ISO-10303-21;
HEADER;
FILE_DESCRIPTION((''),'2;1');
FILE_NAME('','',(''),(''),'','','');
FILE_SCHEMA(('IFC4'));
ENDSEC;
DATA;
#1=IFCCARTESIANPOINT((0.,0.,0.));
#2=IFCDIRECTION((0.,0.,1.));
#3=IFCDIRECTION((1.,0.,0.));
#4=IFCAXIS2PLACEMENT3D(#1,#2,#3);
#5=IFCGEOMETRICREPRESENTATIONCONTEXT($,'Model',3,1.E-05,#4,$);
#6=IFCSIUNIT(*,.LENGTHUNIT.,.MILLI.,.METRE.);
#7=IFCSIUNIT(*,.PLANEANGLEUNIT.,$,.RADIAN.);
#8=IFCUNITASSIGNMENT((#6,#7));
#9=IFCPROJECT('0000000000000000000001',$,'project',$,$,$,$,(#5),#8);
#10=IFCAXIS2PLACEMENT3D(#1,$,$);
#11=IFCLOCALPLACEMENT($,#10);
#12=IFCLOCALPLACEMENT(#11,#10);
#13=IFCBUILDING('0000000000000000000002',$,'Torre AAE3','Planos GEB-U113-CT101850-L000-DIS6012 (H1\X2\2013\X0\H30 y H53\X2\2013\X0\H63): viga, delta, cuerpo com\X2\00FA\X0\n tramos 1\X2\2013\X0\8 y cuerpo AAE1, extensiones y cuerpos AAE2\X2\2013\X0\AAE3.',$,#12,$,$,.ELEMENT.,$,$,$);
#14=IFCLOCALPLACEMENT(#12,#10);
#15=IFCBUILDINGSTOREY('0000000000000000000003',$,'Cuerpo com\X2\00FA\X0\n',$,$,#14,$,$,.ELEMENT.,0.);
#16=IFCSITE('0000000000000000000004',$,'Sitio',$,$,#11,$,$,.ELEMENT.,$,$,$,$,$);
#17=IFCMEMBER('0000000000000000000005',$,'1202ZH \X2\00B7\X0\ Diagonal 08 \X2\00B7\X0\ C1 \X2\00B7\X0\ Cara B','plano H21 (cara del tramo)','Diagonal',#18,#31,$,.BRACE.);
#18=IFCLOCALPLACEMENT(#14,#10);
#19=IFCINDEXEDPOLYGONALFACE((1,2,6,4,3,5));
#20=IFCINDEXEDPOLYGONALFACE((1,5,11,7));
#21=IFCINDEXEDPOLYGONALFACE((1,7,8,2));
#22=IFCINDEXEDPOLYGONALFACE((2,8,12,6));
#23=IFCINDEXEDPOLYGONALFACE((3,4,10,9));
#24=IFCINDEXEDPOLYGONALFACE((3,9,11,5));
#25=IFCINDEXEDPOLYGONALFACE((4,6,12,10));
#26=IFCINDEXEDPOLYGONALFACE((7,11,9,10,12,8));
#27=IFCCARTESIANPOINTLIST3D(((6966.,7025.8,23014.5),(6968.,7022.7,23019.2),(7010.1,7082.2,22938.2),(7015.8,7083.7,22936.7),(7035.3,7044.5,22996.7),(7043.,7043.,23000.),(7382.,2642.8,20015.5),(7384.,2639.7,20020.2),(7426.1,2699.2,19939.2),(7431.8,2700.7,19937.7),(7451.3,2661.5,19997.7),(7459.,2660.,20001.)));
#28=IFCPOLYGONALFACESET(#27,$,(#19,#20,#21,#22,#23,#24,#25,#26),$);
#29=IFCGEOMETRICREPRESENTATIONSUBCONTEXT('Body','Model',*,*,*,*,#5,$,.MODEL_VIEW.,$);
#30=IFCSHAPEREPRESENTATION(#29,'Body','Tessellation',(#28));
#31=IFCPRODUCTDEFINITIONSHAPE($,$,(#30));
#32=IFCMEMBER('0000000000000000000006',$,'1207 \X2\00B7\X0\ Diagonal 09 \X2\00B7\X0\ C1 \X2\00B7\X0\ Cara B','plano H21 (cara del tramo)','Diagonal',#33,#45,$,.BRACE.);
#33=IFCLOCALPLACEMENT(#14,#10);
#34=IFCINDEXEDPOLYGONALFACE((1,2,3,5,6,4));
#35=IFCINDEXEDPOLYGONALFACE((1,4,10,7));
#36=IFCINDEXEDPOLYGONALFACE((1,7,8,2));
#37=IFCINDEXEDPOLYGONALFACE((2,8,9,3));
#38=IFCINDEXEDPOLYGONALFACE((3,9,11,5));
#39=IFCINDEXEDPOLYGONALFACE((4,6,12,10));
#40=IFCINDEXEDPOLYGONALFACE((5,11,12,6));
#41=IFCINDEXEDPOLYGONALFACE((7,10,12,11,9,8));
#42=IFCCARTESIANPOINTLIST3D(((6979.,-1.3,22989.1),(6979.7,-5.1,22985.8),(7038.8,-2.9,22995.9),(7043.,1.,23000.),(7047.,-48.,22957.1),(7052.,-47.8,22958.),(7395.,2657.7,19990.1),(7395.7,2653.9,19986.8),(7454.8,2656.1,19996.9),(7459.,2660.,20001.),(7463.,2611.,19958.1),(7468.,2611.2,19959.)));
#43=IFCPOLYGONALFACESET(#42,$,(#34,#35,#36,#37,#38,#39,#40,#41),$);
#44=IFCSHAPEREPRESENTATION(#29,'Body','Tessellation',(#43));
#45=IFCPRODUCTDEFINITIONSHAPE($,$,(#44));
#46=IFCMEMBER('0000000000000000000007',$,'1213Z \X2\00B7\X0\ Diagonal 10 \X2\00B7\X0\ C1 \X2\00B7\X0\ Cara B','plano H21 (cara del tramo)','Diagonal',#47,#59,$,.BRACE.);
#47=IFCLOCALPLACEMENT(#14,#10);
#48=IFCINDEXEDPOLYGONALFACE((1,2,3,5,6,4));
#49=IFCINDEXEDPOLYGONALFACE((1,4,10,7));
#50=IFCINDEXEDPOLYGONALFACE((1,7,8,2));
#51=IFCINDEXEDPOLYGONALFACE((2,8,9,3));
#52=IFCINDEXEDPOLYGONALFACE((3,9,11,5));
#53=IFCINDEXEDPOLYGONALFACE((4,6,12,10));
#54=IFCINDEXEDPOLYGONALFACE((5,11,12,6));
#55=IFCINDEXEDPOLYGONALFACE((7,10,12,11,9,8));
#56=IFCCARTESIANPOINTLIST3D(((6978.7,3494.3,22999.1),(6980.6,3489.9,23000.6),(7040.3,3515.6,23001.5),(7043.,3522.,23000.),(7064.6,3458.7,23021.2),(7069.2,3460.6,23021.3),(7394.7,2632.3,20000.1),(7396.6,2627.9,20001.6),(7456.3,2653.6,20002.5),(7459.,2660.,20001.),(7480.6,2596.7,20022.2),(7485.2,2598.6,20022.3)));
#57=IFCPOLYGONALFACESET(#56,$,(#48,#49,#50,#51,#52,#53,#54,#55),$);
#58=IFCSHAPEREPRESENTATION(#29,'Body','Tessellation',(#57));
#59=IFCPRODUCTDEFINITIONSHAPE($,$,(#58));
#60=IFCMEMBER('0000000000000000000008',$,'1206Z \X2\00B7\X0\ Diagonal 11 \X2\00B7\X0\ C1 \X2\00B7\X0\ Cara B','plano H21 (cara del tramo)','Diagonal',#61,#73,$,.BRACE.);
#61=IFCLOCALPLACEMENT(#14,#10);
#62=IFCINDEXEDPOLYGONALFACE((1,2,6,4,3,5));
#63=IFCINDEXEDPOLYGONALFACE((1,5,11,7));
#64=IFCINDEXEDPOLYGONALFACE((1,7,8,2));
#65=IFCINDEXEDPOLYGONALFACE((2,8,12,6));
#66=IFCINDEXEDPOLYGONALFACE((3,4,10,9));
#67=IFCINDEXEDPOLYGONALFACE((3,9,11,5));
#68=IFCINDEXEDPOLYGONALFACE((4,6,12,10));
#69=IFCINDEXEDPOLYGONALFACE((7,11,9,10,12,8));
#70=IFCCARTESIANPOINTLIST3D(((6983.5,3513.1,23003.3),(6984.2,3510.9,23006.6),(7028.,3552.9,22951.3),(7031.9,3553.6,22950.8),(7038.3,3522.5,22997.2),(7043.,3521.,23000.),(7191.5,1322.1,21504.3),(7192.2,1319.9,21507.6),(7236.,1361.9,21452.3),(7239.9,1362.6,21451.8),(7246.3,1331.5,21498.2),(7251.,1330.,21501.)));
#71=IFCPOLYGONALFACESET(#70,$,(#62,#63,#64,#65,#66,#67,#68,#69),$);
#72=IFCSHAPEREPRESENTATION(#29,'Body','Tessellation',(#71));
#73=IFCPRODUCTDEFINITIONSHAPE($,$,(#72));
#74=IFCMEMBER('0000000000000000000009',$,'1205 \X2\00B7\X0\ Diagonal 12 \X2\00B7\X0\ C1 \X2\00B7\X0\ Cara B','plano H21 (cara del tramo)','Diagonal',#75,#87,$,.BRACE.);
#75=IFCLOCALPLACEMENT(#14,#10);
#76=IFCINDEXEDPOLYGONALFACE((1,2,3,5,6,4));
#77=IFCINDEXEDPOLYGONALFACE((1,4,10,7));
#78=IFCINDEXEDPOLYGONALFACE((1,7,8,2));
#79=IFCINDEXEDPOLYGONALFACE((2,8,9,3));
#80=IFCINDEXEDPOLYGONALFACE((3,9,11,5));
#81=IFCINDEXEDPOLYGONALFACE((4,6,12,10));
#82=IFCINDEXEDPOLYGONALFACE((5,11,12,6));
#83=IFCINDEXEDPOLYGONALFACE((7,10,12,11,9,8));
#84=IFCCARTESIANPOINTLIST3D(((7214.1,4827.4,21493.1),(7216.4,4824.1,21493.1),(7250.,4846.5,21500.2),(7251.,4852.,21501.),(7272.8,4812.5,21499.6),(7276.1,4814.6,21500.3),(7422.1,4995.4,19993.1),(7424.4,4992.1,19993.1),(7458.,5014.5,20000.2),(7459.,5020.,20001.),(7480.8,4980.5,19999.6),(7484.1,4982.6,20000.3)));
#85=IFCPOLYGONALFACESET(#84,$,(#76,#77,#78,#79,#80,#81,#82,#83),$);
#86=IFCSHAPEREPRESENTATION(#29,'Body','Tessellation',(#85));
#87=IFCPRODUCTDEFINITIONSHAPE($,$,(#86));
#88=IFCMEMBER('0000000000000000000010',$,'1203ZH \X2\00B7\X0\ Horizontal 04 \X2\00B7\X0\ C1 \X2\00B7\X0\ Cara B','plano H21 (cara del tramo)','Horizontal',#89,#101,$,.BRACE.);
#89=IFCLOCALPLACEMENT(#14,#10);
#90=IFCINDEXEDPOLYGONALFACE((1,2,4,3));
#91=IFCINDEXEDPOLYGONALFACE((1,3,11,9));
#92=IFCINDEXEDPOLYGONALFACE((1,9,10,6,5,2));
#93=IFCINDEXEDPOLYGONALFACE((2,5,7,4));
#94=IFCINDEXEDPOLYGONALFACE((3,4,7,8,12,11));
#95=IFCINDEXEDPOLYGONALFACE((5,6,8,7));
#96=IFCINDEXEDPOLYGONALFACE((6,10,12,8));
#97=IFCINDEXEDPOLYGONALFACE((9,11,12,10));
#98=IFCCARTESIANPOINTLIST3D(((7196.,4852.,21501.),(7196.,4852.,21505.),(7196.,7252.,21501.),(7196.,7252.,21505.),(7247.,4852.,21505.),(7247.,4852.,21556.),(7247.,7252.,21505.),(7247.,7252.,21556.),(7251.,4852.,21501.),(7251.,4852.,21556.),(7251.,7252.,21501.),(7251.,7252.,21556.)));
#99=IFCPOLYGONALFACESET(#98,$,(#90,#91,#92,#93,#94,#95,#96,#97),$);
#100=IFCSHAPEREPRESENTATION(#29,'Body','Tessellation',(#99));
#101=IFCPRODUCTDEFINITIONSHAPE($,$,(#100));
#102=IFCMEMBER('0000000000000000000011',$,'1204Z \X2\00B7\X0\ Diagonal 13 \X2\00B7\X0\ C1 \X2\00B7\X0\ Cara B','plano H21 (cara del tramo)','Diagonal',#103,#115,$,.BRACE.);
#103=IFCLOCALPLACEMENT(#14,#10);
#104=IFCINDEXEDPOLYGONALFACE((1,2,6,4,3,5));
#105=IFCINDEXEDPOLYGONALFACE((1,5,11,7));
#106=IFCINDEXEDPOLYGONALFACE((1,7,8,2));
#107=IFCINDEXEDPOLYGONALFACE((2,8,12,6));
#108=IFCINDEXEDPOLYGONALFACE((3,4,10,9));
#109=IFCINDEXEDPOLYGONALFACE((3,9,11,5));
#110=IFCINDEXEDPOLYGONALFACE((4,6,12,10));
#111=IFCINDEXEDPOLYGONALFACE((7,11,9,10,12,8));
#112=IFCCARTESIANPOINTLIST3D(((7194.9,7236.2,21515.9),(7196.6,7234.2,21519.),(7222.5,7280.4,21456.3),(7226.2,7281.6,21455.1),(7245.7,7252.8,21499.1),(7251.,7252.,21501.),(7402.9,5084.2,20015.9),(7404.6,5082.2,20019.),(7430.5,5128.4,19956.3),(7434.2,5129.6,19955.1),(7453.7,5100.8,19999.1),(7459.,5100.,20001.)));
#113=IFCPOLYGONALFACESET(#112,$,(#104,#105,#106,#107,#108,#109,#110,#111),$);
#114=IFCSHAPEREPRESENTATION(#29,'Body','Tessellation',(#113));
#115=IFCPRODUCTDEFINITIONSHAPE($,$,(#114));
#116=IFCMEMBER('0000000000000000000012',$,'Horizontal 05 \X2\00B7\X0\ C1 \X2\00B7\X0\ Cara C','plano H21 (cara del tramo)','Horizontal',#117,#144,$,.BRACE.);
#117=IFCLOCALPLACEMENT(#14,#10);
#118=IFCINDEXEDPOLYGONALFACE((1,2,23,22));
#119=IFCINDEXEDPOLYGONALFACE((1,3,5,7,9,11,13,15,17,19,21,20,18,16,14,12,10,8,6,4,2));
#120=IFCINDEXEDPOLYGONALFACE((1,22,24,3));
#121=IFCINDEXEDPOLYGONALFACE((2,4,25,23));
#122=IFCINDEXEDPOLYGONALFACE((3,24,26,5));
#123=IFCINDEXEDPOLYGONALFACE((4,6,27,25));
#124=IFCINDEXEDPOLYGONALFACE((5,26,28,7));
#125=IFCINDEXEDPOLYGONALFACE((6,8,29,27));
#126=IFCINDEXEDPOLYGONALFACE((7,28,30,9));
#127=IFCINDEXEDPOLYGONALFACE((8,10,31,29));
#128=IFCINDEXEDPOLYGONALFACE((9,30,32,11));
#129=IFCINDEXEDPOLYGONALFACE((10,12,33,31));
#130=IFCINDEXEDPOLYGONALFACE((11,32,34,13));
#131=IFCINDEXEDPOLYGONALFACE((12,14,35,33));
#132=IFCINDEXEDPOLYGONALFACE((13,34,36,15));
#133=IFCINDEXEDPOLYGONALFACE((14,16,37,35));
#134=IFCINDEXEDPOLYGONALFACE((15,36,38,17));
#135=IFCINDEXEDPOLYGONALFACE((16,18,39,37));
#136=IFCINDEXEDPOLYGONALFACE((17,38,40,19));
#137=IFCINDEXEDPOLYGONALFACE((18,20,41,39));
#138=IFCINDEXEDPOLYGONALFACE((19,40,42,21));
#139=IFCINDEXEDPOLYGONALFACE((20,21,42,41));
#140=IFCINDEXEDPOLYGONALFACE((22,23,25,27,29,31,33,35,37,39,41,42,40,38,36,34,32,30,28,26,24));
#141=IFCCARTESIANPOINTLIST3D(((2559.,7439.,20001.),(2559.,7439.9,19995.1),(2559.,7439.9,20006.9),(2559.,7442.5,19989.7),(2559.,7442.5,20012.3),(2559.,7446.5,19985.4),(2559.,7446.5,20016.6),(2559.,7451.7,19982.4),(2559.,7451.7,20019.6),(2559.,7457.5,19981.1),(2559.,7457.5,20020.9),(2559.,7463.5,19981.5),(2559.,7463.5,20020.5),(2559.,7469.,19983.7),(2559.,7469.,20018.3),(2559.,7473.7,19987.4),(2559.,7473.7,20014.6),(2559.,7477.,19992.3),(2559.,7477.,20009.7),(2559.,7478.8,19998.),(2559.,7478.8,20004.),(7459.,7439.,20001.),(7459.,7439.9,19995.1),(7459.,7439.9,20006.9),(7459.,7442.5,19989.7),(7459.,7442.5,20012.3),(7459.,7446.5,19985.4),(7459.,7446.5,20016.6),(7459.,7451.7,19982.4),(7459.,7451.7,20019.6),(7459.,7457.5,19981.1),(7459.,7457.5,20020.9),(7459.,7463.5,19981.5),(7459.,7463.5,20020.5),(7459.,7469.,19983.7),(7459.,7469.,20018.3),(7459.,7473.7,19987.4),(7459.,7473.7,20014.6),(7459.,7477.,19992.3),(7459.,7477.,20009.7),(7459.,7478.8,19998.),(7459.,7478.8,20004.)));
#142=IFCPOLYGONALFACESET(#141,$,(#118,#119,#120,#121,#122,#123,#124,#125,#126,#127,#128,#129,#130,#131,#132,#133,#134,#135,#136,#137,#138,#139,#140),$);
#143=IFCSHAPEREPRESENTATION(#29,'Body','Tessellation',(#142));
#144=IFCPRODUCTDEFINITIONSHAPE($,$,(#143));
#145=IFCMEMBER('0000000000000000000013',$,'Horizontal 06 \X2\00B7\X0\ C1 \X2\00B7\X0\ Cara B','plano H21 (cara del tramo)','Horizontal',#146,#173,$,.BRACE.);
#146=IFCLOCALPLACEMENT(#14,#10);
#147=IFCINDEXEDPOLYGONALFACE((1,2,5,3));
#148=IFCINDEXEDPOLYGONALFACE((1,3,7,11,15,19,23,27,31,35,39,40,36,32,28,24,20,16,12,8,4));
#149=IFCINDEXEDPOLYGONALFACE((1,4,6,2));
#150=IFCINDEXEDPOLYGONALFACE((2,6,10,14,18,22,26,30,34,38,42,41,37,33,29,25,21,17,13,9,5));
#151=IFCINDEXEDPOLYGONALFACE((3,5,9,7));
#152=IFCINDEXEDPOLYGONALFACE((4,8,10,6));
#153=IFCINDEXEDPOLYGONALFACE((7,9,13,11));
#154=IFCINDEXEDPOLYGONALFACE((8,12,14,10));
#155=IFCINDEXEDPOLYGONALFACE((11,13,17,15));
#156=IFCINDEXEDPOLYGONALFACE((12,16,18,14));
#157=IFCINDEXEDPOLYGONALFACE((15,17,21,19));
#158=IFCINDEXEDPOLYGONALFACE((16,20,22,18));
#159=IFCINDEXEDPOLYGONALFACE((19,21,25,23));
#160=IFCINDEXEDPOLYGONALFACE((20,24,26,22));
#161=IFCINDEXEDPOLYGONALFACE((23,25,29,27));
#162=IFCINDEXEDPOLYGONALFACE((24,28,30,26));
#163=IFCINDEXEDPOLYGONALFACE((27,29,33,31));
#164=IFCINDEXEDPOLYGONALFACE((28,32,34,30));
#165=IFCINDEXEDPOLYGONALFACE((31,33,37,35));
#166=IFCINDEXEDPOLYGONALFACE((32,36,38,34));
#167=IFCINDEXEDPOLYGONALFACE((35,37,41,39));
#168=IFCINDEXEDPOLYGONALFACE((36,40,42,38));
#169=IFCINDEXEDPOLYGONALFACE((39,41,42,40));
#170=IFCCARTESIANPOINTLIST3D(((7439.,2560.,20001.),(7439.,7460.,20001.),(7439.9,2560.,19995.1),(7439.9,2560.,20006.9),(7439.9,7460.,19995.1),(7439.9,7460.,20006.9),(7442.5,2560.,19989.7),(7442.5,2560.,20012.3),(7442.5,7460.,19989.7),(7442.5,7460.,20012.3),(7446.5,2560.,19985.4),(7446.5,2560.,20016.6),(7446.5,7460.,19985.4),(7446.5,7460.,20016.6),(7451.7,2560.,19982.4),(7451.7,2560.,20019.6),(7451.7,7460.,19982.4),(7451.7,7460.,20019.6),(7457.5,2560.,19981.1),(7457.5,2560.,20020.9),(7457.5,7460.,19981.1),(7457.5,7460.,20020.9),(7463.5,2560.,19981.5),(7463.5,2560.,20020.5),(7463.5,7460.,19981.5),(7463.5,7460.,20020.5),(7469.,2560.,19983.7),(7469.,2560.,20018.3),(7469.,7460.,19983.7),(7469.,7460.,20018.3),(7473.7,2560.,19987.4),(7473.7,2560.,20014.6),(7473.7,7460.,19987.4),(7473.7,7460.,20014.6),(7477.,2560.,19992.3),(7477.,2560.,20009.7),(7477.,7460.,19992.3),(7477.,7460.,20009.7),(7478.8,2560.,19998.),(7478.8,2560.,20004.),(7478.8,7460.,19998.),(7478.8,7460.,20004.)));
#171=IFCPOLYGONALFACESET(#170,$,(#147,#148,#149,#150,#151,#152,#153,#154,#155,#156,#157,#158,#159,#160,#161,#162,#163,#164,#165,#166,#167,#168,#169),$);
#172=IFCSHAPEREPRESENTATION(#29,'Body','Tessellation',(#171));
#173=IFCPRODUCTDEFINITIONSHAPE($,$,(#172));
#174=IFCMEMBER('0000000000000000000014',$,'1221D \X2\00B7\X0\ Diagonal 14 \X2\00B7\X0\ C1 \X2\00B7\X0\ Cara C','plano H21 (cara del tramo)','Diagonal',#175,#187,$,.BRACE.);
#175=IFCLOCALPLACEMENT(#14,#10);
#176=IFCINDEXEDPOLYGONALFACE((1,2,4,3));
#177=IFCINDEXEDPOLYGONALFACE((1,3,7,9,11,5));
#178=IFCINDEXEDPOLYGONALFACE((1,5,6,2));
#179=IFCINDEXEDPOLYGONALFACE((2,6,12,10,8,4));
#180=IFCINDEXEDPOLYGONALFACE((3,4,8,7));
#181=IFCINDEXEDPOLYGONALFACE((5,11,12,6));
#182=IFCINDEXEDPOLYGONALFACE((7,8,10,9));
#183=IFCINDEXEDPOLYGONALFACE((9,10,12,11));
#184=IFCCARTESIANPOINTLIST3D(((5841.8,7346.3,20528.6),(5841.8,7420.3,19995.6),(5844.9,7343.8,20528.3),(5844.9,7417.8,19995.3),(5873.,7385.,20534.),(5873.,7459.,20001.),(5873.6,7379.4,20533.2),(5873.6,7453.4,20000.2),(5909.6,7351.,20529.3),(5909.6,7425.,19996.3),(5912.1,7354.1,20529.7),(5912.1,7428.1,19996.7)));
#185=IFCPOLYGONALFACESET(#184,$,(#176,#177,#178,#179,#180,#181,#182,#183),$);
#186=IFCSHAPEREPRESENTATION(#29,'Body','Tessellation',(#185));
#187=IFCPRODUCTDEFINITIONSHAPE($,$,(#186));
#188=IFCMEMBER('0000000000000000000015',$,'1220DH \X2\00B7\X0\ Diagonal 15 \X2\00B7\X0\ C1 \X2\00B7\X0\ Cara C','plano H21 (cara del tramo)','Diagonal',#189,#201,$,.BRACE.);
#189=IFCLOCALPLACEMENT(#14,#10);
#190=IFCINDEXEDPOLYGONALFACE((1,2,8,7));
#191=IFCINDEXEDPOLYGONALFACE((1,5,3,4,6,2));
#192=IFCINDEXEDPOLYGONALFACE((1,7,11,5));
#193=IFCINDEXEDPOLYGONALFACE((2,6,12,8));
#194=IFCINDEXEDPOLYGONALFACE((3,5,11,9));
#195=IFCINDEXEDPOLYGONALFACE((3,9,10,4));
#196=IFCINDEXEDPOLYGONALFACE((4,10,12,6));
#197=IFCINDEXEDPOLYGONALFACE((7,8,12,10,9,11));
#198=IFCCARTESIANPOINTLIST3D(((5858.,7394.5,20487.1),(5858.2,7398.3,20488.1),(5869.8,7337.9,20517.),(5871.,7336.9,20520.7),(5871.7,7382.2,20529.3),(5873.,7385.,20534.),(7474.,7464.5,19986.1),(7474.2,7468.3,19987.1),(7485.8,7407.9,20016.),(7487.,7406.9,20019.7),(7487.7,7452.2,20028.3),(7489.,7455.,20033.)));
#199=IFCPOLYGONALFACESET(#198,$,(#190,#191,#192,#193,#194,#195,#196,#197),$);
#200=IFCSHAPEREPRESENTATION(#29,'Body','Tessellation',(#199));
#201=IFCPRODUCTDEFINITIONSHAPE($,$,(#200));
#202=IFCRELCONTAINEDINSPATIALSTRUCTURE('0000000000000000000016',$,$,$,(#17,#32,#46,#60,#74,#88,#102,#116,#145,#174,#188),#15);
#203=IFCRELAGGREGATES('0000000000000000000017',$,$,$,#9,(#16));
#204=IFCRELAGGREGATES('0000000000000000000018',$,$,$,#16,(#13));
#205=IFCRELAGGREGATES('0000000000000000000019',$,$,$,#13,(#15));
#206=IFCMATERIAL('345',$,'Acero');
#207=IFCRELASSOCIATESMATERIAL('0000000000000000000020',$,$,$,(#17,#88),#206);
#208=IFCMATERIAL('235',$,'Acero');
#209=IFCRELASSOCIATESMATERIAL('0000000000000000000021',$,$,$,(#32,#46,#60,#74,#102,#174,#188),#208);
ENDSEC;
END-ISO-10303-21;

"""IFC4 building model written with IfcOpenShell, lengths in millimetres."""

from ifc_helpers import new_model, si_unit, frame, frame_2d, origin, origin_with_axes, place, context, subcontext, project, spatial, circle, l_section, extrude, material, element, save


model = new_model("IFC4")

# Units and contexts
model_context = context("Model", 3, precision=1e-05, world=origin_with_axes())
body_context = subcontext(model_context, "Body", "Model", "MODEL_VIEW")
ifc_project = project(units=[si_unit("LENGTHUNIT", "METRE", prefix="MILLI"), si_unit("PLANEANGLEUNIT", "RADIAN")], contexts=[model_context])

# Site, building, storey
site_placement = place(None, origin())
site = spatial("IfcSite", under=ifc_project, at=site_placement, Name="Sitio", CompositionType="ELEMENT")
building_placement = place(site_placement, origin())
building = spatial("IfcBuilding", under=site, at=building_placement, Name="Torre AAE3", Description="Planos GEB-U113-CT101850-L000-DIS6012 (H1–H30 y H53–H63): viga, delta, cuerpo común tramos 1–8 y cuerpo AAE1, extensiones y cuerpos AAE2–AAE3.", CompositionType="ELEMENT")
storey_placement = place(building_placement, origin())
storey = spatial("IfcBuildingStorey", under=building, at=storey_placement, Name="Cuerpo común", CompositionType="ELEMENT", Elevation=0.0)

# Members
ifc_material_1 = material(Name="345", Category="Acero")
ifc_material_2 = material(Name="235", Category="Acero")
member_1_placement = place(storey_placement, frame((7043.0, 7043.0, 23000.0), z_axis=(0.078092, -0.822778, -0.562973), x_axis=(-0.937033, -0.253386, 0.240342)))
element("IfcMember", 1, at=member_1_placement, inside=storey, material=ifc_material_1, Name="1202ZH · Diagonal 08 · C1 · Cara B", Description="plano H21 (cara del tramo)", ObjectType="Diagonal", PredefinedType="BRACE", context=body_context, shape_type="SweptSolid", body=[
    extrude(l_section(Depth=80.0, Width=80.0, Thickness=6.0, at=frame_2d((40.0, 40.0))), None, (0.0, 0.0, 1.0), 5327.1),
])
member_2_placement = place(storey_placement, frame((7459.0, 2660.0, 20001.0), z_axis=(-0.103237, -0.659874, 0.74425), x_axis=(-0.985077, -0.035769, -0.168357)))
element("IfcMember", 2, at=member_2_placement, inside=storey, material=ifc_material_2, Name="1207 · Diagonal 09 · C1 · Cara B", Description="plano H21 (cara del tramo)", ObjectType="Diagonal", PredefinedType="BRACE", context=body_context, shape_type="SweptSolid", body=[
    extrude(l_section(Depth=65.0, Width=65.0, Thickness=5.0, at=frame_2d((32.5, 32.5))), None, (0.0, 0.0, 1.0), 4029.6),
])
member_3_placement = place(storey_placement, frame((7459.0, 2660.0, 20001.0), z_axis=(-0.132146, 0.273822, 0.952659), x_axis=(-0.918122, -0.396066, -0.013514)))
element("IfcMember", 3, at=member_3_placement, inside=storey, material=ifc_material_2, Name="1213Z · Diagonal 10 · C1 · Cara B", Description="plano H21 (cara del tramo)", ObjectType="Diagonal", PredefinedType="BRACE", context=body_context, shape_type="SweptSolid", body=[
    extrude(l_section(Depth=70.0, Width=70.0, Thickness=5.0, at=frame_2d((35.0, 35.0))), None, (0.0, 0.0, 1.0), 3148.0),
])
member_4_placement = place(storey_placement, frame((7043.0, 3521.0, 23000.0), z_axis=(0.078112, -0.822804, -0.562932), x_axis=(-0.979764, -0.167732, 0.109213)))
element("IfcMember", 4, at=member_4_placement, inside=storey, material=ifc_material_2, Name="1206Z · Diagonal 11 · C1 · Cara B", Description="plano H21 (cara del tramo)", ObjectType="Diagonal", PredefinedType="BRACE", context=body_context, shape_type="SweptSolid", body=[
    extrude(l_section(Depth=60.0, Width=60.0, Thickness=4.0, at=frame_2d((30.0, 30.0))), None, (0.0, 0.0, 1.0), 2662.8),
])
member_5_placement = place(storey_placement, frame((7459.0, 5020.0, 20001.0), z_axis=(-0.136515, -0.110262, 0.984483), x_axis=(-0.819092, -0.546389, -0.174776)))
element("IfcMember", 5, at=member_5_placement, inside=storey, material=ifc_material_2, Name="1205 · Diagonal 12 · C1 · Cara B", Description="plano H21 (cara del tramo)", ObjectType="Diagonal", PredefinedType="BRACE", context=body_context, shape_type="SweptSolid", body=[
    extrude(l_section(Depth=45.0, Width=45.0, Thickness=4.0, at=frame_2d((22.5, 22.5))), None, (0.0, 0.0, 1.0), 1523.6),
])
member_6_placement = place(storey_placement, frame((7251.0, 4852.0, 21501.0), z_axis=(0.0, 1.0, 0.0), x_axis=(-1.0, 0.0, 0.0)))
element("IfcMember", 6, at=member_6_placement, inside=storey, material=ifc_material_1, Name="1203ZH · Horizontal 04 · C1 · Cara B", Description="plano H21 (cara del tramo)", ObjectType="Horizontal", PredefinedType="BRACE", context=body_context, shape_type="SweptSolid", body=[
    extrude(l_section(Depth=55.0, Width=55.0, Thickness=4.0, at=frame_2d((27.5, 27.5))), None, (0.0, 0.0, 1.0), 2400.0),
])
member_7_placement = place(storey_placement, frame((7251.0, 7252.0, 21501.0), z_axis=(0.079045, -0.81781, -0.570035), x_axis=(-0.906773, -0.296545, 0.299704)))
element("IfcMember", 7, at=member_7_placement, inside=storey, material=ifc_material_2, Name="1204Z · Diagonal 13 · C1 · Cara B", Description="plano H21 (cara del tramo)", ObjectType="Diagonal", PredefinedType="BRACE", context=body_context, shape_type="SweptSolid", body=[
    extrude(l_section(Depth=60.0, Width=60.0, Thickness=4.0, at=frame_2d((30.0, 30.0))), None, (0.0, 0.0, 1.0), 2631.4),
])
for number, where, z_axis, x_axis, name in (
    (8, (7459.0, 7459.0, 20001.0), (-1.0, 0.0, 0.0), (0.0, -1.0, 0.0), "Horizontal 05 · C1 · Cara C"),
    (9, (7459.0, 7460.0, 20001.0), (0.0, -1.0, 0.0), (-1.0, 0.0, 0.0), "Horizontal 06 · C1 · Cara B"),
):
    element("IfcMember", number, at=place(storey_placement, frame(where, z_axis=z_axis, x_axis=x_axis)), inside=storey, Name=name, Description="plano H21 (cara del tramo)", ObjectType="Horizontal", PredefinedType="BRACE", context=body_context, shape_type="SweptSolid", body=[
        extrude(circle(Radius=20.0), None, (0.0, 0.0, 1.0), 4900.0),
    ])
member_8_placement = place(storey_placement, frame((5873.0, 7459.0, 20001.0), z_axis=(0.0, -0.137518, 0.990499), x_axis=(-0.624164, -0.77387, -0.107442)))
element("IfcMember", 10, at=member_8_placement, inside=storey, material=ifc_material_2, Name="1221D · Diagonal 14 · C1 · Cara C", Description="plano H21 (cara del tramo)", ObjectType="Diagonal", PredefinedType="BRACE", context=body_context, shape_type="SweptSolid", body=[
    extrude(l_section(Depth=50.0, Width=50.0, Thickness=4.0, at=frame_2d((25.0, 25.0))), None, (0.0, 0.0, 1.0), 538.1),
])
member_9_placement = place(storey_placement, frame((5873.0, 7385.0, 20534.0), z_axis=(0.954334, 0.041339, -0.295867), x_axis=(-0.040915, -0.962961, -0.266519)))
element("IfcMember", 11, at=member_9_placement, inside=storey, material=ifc_material_2, Name="1220DH · Diagonal 15 · C1 · Cara C", Description="plano H21 (cara del tramo)", ObjectType="Diagonal", PredefinedType="BRACE", context=body_context, shape_type="SweptSolid", body=[
    extrude(l_section(Depth=50.0, Width=50.0, Thickness=4.0, at=frame_2d((25.0, 25.0))), None, (0.0, 0.0, 1.0), 1693.3),
])

save(model, "model.ifc")
